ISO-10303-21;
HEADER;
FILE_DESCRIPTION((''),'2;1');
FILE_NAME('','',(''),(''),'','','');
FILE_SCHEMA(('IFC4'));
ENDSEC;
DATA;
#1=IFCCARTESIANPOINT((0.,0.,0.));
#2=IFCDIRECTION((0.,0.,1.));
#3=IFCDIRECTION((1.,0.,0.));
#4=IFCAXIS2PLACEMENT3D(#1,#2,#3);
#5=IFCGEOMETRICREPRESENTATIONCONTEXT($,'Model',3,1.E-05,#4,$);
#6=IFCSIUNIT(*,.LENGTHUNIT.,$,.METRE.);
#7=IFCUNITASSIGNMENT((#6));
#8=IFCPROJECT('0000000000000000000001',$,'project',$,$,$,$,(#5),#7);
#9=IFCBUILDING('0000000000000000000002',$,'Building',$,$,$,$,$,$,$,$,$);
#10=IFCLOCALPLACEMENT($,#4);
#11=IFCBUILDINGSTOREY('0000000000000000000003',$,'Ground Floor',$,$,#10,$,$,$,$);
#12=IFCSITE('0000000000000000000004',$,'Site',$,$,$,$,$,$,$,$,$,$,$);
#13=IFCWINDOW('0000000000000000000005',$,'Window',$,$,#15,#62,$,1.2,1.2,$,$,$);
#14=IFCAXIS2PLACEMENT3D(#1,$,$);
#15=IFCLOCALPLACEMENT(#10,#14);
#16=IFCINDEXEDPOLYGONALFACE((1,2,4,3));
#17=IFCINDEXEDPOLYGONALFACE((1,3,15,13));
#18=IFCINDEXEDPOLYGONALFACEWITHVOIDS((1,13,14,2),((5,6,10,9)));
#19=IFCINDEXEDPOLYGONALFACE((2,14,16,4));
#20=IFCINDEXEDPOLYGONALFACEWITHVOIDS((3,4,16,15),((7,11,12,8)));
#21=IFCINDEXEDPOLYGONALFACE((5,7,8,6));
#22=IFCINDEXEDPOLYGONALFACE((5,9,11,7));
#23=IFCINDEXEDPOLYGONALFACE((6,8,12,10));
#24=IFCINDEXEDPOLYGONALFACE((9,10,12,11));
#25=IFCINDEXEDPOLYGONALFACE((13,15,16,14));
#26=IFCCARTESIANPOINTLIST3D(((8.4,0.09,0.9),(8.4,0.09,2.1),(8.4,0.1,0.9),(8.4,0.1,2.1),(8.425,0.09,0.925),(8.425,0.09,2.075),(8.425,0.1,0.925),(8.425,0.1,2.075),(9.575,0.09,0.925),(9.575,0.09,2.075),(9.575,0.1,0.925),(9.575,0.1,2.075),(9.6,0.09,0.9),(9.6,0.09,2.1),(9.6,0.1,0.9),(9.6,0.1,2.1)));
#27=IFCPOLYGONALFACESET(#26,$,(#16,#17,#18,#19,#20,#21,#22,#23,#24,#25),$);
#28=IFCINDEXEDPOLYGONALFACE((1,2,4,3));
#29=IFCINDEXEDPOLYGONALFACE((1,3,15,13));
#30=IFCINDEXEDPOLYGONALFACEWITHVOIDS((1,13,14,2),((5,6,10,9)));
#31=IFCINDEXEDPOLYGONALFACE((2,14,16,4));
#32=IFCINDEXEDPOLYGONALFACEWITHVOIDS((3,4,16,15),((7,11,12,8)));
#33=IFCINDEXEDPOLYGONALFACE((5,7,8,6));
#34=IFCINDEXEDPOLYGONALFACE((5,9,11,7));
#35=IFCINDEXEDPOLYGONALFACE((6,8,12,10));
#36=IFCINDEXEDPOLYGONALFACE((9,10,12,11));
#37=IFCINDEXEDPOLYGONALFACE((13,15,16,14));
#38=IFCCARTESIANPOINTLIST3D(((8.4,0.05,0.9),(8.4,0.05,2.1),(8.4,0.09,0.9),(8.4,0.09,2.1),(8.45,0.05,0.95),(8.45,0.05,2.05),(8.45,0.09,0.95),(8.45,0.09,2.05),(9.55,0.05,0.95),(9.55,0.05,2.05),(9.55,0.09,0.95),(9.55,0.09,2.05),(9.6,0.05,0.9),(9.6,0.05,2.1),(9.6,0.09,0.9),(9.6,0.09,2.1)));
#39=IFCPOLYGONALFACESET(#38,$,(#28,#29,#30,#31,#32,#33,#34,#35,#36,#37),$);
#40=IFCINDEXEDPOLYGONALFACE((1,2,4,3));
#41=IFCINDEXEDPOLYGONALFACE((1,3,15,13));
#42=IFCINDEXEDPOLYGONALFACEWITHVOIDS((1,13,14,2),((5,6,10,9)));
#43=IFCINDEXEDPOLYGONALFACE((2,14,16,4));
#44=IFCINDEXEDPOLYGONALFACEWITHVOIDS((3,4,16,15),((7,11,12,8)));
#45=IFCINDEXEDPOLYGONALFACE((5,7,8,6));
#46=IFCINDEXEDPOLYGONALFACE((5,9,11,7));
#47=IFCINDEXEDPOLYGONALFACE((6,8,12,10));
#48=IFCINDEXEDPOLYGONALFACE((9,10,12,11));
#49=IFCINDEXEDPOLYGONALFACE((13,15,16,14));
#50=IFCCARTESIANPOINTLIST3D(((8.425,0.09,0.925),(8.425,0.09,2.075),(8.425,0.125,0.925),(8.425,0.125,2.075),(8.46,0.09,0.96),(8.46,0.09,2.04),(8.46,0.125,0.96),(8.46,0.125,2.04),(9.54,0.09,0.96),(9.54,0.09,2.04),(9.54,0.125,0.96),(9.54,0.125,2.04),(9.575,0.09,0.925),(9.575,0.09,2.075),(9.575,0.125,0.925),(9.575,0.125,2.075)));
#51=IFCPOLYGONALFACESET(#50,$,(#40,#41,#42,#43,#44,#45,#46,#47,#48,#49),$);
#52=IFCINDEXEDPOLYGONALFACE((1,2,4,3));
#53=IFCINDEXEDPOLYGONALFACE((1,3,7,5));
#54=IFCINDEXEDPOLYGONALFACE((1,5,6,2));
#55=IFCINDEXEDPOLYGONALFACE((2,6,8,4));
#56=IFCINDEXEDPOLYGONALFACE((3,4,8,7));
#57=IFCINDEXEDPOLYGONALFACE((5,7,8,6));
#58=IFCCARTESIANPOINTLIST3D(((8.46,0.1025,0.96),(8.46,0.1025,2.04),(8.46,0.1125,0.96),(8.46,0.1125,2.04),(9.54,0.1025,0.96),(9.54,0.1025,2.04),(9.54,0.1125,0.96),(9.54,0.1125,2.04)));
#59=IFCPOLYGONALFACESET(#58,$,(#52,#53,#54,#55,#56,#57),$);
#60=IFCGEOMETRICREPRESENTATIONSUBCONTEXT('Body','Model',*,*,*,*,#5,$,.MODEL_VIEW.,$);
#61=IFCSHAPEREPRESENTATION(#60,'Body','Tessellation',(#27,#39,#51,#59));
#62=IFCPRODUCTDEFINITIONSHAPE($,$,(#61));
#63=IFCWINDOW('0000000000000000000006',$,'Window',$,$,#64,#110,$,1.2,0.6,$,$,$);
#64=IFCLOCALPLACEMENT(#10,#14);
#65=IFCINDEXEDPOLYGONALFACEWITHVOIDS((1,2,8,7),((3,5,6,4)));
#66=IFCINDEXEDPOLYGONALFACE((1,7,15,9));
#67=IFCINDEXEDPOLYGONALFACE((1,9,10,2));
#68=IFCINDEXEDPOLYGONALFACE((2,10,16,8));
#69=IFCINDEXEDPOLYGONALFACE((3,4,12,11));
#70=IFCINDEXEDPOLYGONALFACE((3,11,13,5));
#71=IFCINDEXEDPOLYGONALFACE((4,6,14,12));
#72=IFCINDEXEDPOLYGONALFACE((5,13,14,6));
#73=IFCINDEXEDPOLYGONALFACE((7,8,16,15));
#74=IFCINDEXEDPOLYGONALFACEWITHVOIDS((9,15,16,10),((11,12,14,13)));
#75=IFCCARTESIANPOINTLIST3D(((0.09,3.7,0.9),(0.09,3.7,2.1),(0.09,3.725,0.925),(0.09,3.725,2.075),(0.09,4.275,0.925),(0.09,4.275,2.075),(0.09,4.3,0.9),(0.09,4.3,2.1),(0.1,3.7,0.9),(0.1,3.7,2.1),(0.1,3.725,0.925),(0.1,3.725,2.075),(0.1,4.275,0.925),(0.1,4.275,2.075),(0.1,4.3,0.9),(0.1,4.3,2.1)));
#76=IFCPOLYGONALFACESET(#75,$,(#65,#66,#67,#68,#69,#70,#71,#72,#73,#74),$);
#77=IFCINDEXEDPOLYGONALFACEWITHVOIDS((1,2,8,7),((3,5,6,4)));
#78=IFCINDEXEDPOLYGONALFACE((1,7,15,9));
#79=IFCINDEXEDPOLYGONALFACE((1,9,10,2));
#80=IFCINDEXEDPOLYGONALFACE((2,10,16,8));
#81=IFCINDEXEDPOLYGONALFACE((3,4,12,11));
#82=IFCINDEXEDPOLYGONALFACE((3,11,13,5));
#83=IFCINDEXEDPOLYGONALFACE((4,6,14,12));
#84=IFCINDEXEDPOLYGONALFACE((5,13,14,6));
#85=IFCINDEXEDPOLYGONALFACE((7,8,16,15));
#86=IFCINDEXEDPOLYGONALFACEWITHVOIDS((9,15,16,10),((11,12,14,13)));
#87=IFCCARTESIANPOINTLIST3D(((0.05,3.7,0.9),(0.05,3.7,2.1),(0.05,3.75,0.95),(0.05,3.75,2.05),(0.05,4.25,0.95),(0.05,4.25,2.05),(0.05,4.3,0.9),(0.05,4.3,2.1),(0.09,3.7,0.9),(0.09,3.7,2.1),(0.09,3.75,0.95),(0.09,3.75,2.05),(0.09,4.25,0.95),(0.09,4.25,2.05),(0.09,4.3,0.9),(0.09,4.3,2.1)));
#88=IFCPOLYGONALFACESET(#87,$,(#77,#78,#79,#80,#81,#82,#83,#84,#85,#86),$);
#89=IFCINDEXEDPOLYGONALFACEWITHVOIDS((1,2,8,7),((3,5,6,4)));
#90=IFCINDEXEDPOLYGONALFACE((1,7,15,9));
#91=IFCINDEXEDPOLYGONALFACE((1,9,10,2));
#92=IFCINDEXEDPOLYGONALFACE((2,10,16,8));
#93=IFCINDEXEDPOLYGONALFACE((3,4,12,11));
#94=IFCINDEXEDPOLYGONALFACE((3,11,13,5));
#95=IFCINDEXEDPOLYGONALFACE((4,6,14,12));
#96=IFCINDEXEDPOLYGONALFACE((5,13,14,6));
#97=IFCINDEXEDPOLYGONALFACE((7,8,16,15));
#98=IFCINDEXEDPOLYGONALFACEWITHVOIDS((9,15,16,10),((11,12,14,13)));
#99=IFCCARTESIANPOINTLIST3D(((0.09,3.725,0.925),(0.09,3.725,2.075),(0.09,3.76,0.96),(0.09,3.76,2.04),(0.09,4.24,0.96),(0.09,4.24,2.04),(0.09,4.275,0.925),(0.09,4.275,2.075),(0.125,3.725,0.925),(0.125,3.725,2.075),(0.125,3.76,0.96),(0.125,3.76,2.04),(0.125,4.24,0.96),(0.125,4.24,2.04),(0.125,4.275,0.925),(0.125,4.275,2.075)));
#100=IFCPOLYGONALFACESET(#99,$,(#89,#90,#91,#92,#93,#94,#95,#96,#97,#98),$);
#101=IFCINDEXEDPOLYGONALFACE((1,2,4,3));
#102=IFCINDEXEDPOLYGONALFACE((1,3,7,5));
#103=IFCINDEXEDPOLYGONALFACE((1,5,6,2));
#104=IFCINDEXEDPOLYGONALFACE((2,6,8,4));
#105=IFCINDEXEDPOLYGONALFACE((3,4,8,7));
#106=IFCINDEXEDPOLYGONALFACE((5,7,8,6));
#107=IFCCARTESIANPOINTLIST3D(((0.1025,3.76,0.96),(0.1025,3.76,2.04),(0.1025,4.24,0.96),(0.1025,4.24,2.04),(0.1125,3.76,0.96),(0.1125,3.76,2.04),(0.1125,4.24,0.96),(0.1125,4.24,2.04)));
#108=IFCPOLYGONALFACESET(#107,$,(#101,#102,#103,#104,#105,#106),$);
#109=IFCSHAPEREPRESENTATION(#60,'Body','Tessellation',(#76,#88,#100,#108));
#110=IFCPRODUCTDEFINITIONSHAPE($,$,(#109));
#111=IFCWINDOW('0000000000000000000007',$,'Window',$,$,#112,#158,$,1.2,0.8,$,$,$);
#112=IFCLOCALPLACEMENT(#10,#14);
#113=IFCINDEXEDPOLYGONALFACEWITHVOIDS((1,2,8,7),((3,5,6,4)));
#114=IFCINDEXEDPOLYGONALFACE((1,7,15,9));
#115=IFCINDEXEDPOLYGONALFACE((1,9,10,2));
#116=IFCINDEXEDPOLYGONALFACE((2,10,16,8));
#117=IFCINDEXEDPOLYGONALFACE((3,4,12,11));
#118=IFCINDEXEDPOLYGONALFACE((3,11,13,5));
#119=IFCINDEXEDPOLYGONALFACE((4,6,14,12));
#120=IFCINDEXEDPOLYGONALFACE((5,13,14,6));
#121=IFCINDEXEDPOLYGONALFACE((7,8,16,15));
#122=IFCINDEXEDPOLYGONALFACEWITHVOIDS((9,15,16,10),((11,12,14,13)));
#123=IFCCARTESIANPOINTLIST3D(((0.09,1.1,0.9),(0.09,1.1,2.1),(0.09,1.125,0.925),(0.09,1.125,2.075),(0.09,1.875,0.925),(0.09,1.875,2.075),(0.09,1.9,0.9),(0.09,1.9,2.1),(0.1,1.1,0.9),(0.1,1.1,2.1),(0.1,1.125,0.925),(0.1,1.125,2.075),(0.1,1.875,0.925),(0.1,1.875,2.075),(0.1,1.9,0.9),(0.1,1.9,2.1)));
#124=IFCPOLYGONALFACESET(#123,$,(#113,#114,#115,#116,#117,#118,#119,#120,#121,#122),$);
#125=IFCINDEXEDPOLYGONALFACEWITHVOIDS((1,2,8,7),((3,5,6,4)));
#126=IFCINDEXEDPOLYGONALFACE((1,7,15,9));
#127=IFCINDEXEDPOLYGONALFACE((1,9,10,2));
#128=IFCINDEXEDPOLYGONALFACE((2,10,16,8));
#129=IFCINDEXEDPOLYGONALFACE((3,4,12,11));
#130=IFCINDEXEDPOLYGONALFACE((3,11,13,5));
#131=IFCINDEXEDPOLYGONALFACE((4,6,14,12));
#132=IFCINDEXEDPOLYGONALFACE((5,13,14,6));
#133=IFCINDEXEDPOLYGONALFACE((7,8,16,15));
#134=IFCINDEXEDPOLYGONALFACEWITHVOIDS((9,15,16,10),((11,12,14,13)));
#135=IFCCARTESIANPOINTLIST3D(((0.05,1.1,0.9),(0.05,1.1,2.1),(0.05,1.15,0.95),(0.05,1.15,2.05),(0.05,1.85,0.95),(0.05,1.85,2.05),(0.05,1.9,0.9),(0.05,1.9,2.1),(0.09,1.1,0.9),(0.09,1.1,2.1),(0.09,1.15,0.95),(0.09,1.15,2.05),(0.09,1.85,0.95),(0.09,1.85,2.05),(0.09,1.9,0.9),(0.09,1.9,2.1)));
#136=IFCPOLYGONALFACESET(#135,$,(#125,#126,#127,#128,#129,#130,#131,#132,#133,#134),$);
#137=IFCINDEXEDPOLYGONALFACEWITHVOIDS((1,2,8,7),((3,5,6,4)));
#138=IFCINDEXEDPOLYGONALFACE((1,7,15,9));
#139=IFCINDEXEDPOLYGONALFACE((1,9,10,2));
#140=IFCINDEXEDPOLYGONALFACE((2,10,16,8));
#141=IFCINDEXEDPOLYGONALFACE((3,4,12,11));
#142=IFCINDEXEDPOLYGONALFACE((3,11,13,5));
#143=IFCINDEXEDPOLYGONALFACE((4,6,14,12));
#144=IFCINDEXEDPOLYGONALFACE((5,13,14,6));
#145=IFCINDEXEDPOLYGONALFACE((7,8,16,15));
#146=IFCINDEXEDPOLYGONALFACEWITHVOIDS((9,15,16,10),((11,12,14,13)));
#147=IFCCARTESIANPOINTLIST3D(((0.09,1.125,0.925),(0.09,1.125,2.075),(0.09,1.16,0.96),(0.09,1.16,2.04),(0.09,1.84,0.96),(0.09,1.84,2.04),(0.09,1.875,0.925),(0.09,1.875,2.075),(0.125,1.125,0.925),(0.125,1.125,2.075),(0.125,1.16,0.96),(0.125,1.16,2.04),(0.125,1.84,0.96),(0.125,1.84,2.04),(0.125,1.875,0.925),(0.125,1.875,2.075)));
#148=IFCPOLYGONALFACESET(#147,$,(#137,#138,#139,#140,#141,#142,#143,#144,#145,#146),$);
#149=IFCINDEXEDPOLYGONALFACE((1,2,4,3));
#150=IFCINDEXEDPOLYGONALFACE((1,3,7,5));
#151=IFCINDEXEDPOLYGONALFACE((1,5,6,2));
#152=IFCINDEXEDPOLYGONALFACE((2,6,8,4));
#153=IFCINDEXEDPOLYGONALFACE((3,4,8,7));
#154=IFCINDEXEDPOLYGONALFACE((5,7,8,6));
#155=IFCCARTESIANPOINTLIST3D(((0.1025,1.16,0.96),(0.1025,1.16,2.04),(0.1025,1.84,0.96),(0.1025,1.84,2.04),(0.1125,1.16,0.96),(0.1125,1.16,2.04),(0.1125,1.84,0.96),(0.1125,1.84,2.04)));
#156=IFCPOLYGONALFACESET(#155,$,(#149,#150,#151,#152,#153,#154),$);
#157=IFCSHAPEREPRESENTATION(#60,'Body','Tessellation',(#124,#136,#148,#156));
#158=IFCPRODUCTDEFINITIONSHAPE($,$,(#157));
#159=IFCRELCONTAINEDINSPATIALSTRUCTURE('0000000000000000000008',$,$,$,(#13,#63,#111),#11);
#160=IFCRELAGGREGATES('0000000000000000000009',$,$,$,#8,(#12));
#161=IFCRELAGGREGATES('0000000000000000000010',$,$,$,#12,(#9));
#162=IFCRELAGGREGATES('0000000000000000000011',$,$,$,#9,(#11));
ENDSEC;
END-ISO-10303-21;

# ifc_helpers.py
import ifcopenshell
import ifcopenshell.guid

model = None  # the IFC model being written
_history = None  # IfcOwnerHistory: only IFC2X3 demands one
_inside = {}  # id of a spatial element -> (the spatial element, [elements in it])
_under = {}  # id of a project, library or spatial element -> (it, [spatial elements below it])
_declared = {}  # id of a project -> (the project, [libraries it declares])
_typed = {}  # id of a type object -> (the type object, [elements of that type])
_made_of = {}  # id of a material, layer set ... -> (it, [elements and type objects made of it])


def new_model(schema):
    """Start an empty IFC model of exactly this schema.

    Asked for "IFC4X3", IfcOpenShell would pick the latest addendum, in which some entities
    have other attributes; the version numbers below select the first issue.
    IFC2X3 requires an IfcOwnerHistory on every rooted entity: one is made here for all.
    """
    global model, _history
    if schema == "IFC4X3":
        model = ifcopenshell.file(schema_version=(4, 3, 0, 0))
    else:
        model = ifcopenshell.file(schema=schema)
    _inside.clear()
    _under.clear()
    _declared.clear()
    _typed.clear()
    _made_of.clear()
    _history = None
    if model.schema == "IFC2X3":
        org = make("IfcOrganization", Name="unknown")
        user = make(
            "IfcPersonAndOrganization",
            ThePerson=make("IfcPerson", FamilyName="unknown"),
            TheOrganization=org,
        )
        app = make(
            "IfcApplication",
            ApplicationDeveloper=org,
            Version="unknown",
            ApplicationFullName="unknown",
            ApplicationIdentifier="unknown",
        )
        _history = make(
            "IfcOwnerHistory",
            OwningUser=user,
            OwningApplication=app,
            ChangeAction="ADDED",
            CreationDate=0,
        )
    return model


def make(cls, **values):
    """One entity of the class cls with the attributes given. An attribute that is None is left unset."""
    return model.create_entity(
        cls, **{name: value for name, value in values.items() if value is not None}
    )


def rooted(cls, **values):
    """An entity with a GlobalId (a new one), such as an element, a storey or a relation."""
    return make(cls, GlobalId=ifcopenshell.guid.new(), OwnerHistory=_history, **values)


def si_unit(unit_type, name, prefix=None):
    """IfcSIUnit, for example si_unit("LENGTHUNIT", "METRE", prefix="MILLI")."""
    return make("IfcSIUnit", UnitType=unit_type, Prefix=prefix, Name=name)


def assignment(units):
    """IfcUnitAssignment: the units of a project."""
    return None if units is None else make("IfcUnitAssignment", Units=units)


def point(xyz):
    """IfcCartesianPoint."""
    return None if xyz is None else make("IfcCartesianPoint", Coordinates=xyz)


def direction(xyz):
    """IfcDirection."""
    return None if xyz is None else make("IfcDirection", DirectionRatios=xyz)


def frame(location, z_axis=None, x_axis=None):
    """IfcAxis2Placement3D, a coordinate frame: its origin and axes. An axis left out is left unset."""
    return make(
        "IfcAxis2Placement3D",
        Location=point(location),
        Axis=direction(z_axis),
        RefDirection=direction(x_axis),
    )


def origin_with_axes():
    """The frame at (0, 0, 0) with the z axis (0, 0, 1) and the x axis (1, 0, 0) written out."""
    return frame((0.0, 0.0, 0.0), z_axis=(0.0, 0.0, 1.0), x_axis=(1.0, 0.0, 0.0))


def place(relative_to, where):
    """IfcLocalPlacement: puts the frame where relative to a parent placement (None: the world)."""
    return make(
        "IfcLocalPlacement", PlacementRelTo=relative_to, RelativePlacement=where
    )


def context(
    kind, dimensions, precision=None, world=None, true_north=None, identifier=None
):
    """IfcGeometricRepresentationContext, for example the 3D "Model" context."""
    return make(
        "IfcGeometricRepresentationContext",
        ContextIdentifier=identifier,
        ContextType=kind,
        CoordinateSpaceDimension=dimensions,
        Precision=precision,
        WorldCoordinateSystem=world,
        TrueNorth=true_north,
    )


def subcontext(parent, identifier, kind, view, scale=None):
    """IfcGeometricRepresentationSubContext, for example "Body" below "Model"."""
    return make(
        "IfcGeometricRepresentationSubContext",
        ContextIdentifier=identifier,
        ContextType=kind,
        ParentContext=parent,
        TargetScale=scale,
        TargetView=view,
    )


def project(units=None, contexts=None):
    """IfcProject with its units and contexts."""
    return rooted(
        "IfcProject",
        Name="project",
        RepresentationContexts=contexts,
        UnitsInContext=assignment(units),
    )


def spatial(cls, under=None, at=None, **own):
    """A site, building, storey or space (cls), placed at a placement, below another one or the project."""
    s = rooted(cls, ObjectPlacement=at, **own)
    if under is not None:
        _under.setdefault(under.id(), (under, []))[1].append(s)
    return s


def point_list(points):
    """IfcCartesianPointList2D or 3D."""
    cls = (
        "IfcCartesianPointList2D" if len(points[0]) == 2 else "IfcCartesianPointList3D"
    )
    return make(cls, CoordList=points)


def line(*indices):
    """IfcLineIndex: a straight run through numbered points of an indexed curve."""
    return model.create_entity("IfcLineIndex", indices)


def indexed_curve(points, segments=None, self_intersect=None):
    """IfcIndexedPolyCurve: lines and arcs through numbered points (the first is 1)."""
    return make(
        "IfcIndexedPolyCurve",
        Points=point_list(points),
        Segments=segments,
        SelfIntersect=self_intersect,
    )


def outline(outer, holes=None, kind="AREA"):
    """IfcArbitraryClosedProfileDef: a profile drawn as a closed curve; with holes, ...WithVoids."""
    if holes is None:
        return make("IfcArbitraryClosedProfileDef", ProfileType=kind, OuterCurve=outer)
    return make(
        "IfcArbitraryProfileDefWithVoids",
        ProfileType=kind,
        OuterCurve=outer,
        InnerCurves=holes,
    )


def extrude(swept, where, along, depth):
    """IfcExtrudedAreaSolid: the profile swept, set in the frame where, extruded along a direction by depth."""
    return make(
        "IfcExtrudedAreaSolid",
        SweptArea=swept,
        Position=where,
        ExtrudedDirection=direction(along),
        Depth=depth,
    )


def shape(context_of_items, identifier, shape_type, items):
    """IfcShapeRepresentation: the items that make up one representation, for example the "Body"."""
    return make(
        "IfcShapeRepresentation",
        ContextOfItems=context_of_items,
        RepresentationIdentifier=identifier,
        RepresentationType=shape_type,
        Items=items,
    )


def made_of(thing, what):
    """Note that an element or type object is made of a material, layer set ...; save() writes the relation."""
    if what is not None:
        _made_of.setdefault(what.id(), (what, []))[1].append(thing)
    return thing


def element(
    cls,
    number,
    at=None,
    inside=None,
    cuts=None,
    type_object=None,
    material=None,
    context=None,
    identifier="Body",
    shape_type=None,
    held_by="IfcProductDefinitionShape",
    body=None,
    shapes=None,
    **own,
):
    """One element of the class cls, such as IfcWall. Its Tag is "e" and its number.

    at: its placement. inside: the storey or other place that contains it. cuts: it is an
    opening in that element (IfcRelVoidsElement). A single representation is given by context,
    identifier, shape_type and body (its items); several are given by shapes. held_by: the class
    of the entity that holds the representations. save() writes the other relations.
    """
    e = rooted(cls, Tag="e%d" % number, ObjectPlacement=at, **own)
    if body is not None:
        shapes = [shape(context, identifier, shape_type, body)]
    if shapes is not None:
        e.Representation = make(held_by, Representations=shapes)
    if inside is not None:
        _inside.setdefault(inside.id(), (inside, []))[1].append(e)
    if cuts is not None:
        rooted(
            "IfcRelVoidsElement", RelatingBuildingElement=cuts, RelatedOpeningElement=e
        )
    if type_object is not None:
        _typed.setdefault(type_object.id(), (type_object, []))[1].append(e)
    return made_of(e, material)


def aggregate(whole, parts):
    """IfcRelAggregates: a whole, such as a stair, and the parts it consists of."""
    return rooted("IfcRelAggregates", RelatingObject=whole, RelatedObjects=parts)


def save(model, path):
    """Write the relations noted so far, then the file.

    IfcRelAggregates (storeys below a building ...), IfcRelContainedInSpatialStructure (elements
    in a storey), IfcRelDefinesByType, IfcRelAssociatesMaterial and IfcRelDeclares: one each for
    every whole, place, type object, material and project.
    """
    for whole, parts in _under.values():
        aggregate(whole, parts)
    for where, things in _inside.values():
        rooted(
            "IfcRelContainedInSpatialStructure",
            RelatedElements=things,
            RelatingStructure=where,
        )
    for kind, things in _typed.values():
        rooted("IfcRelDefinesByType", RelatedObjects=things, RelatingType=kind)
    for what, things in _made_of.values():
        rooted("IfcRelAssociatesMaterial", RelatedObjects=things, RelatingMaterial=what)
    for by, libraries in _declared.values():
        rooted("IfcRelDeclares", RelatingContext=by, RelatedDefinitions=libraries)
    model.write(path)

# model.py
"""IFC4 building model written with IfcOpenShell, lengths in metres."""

from ifc_helpers import new_model, si_unit, frame, origin_with_axes, place, context, subcontext, project, spatial, line, indexed_curve, outline, extrude, element, save


model = new_model("IFC4")

# Units and contexts
model_context = context("Model", 3, precision=1e-05, world=origin_with_axes())
body_context = subcontext(model_context, "Body", "Model", "MODEL_VIEW")
ifc_project = project(units=[si_unit("LENGTHUNIT", "METRE")], contexts=[model_context])

# Site, building, storey
site = spatial("IfcSite", under=ifc_project, Name="Site")
building = spatial("IfcBuilding", under=site, Name="Building")
storey_placement = place(None, origin_with_axes())
storey = spatial("IfcBuildingStorey", under=building, at=storey_placement, Name="Ground Floor")

# Windows
window_1_placement = place(storey_placement, frame((8.4, 0.0, 0.9), z_axis=(0.0, 0.0, 1.0), x_axis=(1.0, 0.0, 0.0)))
element("IfcWindow", 1, at=window_1_placement, inside=storey, Name="Window", OverallHeight=1.2, OverallWidth=1.2, context=body_context, shape_type="SweptSolid", body=[
    extrude(outline(indexed_curve([(0.0, 0.0), (1.2, 0.0), (1.2, 1.2), (0.0, 1.2)], segments=[line(1, 2, 3, 4, 1)]), holes=[indexed_curve([(0.025, 0.025), (1.175, 0.025), (1.175, 1.175), (0.025, 1.175)], segments=[line(1, 2, 3, 4, 1)])]), frame((0.0, 0.09, 0.0), z_axis=(0.0, -1.0, 0.0), x_axis=(1.0, 0.0, 0.0)), (0.0, 0.0, -1.0), 0.01),
    extrude(outline(indexed_curve([(0.0, 0.0), (1.2, 0.0), (1.2, 1.2), (0.0, 1.2)], segments=[line(1, 2, 3, 4, 1)]), holes=[indexed_curve([(0.05, 0.05), (1.15, 0.05), (1.15, 1.15), (0.05, 1.15)], segments=[line(1, 2, 3, 4, 1)])]), frame((0.0, 0.05, 0.0), z_axis=(0.0, -1.0, 0.0), x_axis=(1.0, 0.0, 0.0)), (0.0, 0.0, -1.0), 0.04),
    extrude(outline(indexed_curve([(0.0, 0.0), (1.15, 0.0), (1.15, 1.15), (0.0, 1.15)], segments=[line(1, 2, 3, 4, 1)]), holes=[indexed_curve([(0.035, 0.035), (1.115, 0.035), (1.115, 1.115), (0.035, 1.115)], segments=[line(1, 2, 3, 4, 1)])]), frame((0.025, 0.09, 0.025), z_axis=(0.0, -1.0, 0.0), x_axis=(1.0, 0.0, 0.0)), (0.0, 0.0, -1.0), 0.035),
    extrude(outline(indexed_curve([(0.035, 0.035), (1.115, 0.035), (1.115, 1.115), (0.035, 1.115)], segments=[line(1, 2, 3, 4, 1)])), frame((0.025, 0.1025, 0.025), z_axis=(0.0, -1.0, 0.0), x_axis=(1.0, 0.0, 0.0)), (0.0, 0.0, -1.0), 0.01),
])
window_2_placement = place(storey_placement, frame((0.0, 4.3, 0.9), z_axis=(0.0, 0.0, 1.0), x_axis=(0.0, -1.0, 0.0)))
element("IfcWindow", 2, at=window_2_placement, inside=storey, Name="Window", OverallHeight=1.2, OverallWidth=0.6, context=body_context, shape_type="SweptSolid", body=[
    extrude(outline(indexed_curve([(0.0, 0.0), (0.6, 0.0), (0.6, 1.2), (0.0, 1.2)], segments=[line(1, 2, 3, 4, 1)]), holes=[indexed_curve([(0.025, 0.025), (0.575, 0.025), (0.575, 1.175), (0.025, 1.175)], segments=[line(1, 2, 3, 4, 1)])]), frame((0.0, 0.09, 0.0), z_axis=(0.0, -1.0, 0.0), x_axis=(1.0, 0.0, 0.0)), (0.0, 0.0, -1.0), 0.01),
    extrude(outline(indexed_curve([(0.0, 0.0), (0.6, 0.0), (0.6, 1.2), (0.0, 1.2)], segments=[line(1, 2, 3, 4, 1)]), holes=[indexed_curve([(0.05, 0.05), (0.55, 0.05), (0.55, 1.15), (0.05, 1.15)], segments=[line(1, 2, 3, 4, 1)])]), frame((0.0, 0.05, 0.0), z_axis=(0.0, -1.0, 0.0), x_axis=(1.0, 0.0, 0.0)), (0.0, 0.0, -1.0), 0.04),
    extrude(outline(indexed_curve([(0.0, 0.0), (0.55, 0.0), (0.55, 1.15), (0.0, 1.15)], segments=[line(1, 2, 3, 4, 1)]), holes=[indexed_curve([(0.035, 0.035), (0.515, 0.035), (0.515, 1.115), (0.035, 1.115)], segments=[line(1, 2, 3, 4, 1)])]), frame((0.025, 0.09, 0.025), z_axis=(0.0, -1.0, 0.0), x_axis=(1.0, 0.0, 0.0)), (0.0, 0.0, -1.0), 0.035),
    extrude(outline(indexed_curve([(0.035, 0.035), (0.515, 0.035), (0.515, 1.115), (0.035, 1.115)], segments=[line(1, 2, 3, 4, 1)])), frame((0.025, 0.1025, 0.025), z_axis=(0.0, -1.0, 0.0), x_axis=(1.0, 0.0, 0.0)), (0.0, 0.0, -1.0), 0.01),
])
window_3_placement = place(storey_placement, frame((0.0, 1.9, 0.9), z_axis=(0.0, 0.0, 1.0), x_axis=(0.0, -1.0, 0.0)))
element("IfcWindow", 3, at=window_3_placement, inside=storey, Name="Window", OverallHeight=1.2, OverallWidth=0.8, context=body_context, shape_type="SweptSolid", body=[
    extrude(outline(indexed_curve([(0.0, 0.0), (0.8, 0.0), (0.8, 1.2), (0.0, 1.2)], segments=[line(1, 2, 3, 4, 1)]), holes=[indexed_curve([(0.025, 0.025), (0.775, 0.025), (0.775, 1.175), (0.025, 1.175)], segments=[line(1, 2, 3, 4, 1)])]), frame((0.0, 0.09, 0.0), z_axis=(0.0, -1.0, 0.0), x_axis=(1.0, 0.0, 0.0)), (0.0, 0.0, -1.0), 0.01),
    extrude(outline(indexed_curve([(0.0, 0.0), (0.8, 0.0), (0.8, 1.2), (0.0, 1.2)], segments=[line(1, 2, 3, 4, 1)]), holes=[indexed_curve([(0.05, 0.05), (0.75, 0.05), (0.75, 1.15), (0.05, 1.15)], segments=[line(1, 2, 3, 4, 1)])]), frame((0.0, 0.05, 0.0), z_axis=(0.0, -1.0, 0.0), x_axis=(1.0, 0.0, 0.0)), (0.0, 0.0, -1.0), 0.04),
    extrude(outline(indexed_curve([(0.0, 0.0), (0.75, 0.0), (0.75, 1.15), (0.0, 1.15)], segments=[line(1, 2, 3, 4, 1)]), holes=[indexed_curve([(0.035, 0.035), (0.715, 0.035), (0.715, 1.115), (0.035, 1.115)], segments=[line(1, 2, 3, 4, 1)])]), frame((0.025, 0.09, 0.025), z_axis=(0.0, -1.0, 0.0), x_axis=(1.0, 0.0, 0.0)), (0.0, 0.0, -1.0), 0.035),
    extrude(outline(indexed_curve([(0.035, 0.035), (0.715, 0.035), (0.715, 1.115), (0.035, 1.115)], segments=[line(1, 2, 3, 4, 1)])), frame((0.025, 0.1025, 0.025), z_axis=(0.0, -1.0, 0.0), x_axis=(1.0, 0.0, 0.0)), (0.0, 0.0, -1.0), 0.01),
])

save(model, "model.ifc")
